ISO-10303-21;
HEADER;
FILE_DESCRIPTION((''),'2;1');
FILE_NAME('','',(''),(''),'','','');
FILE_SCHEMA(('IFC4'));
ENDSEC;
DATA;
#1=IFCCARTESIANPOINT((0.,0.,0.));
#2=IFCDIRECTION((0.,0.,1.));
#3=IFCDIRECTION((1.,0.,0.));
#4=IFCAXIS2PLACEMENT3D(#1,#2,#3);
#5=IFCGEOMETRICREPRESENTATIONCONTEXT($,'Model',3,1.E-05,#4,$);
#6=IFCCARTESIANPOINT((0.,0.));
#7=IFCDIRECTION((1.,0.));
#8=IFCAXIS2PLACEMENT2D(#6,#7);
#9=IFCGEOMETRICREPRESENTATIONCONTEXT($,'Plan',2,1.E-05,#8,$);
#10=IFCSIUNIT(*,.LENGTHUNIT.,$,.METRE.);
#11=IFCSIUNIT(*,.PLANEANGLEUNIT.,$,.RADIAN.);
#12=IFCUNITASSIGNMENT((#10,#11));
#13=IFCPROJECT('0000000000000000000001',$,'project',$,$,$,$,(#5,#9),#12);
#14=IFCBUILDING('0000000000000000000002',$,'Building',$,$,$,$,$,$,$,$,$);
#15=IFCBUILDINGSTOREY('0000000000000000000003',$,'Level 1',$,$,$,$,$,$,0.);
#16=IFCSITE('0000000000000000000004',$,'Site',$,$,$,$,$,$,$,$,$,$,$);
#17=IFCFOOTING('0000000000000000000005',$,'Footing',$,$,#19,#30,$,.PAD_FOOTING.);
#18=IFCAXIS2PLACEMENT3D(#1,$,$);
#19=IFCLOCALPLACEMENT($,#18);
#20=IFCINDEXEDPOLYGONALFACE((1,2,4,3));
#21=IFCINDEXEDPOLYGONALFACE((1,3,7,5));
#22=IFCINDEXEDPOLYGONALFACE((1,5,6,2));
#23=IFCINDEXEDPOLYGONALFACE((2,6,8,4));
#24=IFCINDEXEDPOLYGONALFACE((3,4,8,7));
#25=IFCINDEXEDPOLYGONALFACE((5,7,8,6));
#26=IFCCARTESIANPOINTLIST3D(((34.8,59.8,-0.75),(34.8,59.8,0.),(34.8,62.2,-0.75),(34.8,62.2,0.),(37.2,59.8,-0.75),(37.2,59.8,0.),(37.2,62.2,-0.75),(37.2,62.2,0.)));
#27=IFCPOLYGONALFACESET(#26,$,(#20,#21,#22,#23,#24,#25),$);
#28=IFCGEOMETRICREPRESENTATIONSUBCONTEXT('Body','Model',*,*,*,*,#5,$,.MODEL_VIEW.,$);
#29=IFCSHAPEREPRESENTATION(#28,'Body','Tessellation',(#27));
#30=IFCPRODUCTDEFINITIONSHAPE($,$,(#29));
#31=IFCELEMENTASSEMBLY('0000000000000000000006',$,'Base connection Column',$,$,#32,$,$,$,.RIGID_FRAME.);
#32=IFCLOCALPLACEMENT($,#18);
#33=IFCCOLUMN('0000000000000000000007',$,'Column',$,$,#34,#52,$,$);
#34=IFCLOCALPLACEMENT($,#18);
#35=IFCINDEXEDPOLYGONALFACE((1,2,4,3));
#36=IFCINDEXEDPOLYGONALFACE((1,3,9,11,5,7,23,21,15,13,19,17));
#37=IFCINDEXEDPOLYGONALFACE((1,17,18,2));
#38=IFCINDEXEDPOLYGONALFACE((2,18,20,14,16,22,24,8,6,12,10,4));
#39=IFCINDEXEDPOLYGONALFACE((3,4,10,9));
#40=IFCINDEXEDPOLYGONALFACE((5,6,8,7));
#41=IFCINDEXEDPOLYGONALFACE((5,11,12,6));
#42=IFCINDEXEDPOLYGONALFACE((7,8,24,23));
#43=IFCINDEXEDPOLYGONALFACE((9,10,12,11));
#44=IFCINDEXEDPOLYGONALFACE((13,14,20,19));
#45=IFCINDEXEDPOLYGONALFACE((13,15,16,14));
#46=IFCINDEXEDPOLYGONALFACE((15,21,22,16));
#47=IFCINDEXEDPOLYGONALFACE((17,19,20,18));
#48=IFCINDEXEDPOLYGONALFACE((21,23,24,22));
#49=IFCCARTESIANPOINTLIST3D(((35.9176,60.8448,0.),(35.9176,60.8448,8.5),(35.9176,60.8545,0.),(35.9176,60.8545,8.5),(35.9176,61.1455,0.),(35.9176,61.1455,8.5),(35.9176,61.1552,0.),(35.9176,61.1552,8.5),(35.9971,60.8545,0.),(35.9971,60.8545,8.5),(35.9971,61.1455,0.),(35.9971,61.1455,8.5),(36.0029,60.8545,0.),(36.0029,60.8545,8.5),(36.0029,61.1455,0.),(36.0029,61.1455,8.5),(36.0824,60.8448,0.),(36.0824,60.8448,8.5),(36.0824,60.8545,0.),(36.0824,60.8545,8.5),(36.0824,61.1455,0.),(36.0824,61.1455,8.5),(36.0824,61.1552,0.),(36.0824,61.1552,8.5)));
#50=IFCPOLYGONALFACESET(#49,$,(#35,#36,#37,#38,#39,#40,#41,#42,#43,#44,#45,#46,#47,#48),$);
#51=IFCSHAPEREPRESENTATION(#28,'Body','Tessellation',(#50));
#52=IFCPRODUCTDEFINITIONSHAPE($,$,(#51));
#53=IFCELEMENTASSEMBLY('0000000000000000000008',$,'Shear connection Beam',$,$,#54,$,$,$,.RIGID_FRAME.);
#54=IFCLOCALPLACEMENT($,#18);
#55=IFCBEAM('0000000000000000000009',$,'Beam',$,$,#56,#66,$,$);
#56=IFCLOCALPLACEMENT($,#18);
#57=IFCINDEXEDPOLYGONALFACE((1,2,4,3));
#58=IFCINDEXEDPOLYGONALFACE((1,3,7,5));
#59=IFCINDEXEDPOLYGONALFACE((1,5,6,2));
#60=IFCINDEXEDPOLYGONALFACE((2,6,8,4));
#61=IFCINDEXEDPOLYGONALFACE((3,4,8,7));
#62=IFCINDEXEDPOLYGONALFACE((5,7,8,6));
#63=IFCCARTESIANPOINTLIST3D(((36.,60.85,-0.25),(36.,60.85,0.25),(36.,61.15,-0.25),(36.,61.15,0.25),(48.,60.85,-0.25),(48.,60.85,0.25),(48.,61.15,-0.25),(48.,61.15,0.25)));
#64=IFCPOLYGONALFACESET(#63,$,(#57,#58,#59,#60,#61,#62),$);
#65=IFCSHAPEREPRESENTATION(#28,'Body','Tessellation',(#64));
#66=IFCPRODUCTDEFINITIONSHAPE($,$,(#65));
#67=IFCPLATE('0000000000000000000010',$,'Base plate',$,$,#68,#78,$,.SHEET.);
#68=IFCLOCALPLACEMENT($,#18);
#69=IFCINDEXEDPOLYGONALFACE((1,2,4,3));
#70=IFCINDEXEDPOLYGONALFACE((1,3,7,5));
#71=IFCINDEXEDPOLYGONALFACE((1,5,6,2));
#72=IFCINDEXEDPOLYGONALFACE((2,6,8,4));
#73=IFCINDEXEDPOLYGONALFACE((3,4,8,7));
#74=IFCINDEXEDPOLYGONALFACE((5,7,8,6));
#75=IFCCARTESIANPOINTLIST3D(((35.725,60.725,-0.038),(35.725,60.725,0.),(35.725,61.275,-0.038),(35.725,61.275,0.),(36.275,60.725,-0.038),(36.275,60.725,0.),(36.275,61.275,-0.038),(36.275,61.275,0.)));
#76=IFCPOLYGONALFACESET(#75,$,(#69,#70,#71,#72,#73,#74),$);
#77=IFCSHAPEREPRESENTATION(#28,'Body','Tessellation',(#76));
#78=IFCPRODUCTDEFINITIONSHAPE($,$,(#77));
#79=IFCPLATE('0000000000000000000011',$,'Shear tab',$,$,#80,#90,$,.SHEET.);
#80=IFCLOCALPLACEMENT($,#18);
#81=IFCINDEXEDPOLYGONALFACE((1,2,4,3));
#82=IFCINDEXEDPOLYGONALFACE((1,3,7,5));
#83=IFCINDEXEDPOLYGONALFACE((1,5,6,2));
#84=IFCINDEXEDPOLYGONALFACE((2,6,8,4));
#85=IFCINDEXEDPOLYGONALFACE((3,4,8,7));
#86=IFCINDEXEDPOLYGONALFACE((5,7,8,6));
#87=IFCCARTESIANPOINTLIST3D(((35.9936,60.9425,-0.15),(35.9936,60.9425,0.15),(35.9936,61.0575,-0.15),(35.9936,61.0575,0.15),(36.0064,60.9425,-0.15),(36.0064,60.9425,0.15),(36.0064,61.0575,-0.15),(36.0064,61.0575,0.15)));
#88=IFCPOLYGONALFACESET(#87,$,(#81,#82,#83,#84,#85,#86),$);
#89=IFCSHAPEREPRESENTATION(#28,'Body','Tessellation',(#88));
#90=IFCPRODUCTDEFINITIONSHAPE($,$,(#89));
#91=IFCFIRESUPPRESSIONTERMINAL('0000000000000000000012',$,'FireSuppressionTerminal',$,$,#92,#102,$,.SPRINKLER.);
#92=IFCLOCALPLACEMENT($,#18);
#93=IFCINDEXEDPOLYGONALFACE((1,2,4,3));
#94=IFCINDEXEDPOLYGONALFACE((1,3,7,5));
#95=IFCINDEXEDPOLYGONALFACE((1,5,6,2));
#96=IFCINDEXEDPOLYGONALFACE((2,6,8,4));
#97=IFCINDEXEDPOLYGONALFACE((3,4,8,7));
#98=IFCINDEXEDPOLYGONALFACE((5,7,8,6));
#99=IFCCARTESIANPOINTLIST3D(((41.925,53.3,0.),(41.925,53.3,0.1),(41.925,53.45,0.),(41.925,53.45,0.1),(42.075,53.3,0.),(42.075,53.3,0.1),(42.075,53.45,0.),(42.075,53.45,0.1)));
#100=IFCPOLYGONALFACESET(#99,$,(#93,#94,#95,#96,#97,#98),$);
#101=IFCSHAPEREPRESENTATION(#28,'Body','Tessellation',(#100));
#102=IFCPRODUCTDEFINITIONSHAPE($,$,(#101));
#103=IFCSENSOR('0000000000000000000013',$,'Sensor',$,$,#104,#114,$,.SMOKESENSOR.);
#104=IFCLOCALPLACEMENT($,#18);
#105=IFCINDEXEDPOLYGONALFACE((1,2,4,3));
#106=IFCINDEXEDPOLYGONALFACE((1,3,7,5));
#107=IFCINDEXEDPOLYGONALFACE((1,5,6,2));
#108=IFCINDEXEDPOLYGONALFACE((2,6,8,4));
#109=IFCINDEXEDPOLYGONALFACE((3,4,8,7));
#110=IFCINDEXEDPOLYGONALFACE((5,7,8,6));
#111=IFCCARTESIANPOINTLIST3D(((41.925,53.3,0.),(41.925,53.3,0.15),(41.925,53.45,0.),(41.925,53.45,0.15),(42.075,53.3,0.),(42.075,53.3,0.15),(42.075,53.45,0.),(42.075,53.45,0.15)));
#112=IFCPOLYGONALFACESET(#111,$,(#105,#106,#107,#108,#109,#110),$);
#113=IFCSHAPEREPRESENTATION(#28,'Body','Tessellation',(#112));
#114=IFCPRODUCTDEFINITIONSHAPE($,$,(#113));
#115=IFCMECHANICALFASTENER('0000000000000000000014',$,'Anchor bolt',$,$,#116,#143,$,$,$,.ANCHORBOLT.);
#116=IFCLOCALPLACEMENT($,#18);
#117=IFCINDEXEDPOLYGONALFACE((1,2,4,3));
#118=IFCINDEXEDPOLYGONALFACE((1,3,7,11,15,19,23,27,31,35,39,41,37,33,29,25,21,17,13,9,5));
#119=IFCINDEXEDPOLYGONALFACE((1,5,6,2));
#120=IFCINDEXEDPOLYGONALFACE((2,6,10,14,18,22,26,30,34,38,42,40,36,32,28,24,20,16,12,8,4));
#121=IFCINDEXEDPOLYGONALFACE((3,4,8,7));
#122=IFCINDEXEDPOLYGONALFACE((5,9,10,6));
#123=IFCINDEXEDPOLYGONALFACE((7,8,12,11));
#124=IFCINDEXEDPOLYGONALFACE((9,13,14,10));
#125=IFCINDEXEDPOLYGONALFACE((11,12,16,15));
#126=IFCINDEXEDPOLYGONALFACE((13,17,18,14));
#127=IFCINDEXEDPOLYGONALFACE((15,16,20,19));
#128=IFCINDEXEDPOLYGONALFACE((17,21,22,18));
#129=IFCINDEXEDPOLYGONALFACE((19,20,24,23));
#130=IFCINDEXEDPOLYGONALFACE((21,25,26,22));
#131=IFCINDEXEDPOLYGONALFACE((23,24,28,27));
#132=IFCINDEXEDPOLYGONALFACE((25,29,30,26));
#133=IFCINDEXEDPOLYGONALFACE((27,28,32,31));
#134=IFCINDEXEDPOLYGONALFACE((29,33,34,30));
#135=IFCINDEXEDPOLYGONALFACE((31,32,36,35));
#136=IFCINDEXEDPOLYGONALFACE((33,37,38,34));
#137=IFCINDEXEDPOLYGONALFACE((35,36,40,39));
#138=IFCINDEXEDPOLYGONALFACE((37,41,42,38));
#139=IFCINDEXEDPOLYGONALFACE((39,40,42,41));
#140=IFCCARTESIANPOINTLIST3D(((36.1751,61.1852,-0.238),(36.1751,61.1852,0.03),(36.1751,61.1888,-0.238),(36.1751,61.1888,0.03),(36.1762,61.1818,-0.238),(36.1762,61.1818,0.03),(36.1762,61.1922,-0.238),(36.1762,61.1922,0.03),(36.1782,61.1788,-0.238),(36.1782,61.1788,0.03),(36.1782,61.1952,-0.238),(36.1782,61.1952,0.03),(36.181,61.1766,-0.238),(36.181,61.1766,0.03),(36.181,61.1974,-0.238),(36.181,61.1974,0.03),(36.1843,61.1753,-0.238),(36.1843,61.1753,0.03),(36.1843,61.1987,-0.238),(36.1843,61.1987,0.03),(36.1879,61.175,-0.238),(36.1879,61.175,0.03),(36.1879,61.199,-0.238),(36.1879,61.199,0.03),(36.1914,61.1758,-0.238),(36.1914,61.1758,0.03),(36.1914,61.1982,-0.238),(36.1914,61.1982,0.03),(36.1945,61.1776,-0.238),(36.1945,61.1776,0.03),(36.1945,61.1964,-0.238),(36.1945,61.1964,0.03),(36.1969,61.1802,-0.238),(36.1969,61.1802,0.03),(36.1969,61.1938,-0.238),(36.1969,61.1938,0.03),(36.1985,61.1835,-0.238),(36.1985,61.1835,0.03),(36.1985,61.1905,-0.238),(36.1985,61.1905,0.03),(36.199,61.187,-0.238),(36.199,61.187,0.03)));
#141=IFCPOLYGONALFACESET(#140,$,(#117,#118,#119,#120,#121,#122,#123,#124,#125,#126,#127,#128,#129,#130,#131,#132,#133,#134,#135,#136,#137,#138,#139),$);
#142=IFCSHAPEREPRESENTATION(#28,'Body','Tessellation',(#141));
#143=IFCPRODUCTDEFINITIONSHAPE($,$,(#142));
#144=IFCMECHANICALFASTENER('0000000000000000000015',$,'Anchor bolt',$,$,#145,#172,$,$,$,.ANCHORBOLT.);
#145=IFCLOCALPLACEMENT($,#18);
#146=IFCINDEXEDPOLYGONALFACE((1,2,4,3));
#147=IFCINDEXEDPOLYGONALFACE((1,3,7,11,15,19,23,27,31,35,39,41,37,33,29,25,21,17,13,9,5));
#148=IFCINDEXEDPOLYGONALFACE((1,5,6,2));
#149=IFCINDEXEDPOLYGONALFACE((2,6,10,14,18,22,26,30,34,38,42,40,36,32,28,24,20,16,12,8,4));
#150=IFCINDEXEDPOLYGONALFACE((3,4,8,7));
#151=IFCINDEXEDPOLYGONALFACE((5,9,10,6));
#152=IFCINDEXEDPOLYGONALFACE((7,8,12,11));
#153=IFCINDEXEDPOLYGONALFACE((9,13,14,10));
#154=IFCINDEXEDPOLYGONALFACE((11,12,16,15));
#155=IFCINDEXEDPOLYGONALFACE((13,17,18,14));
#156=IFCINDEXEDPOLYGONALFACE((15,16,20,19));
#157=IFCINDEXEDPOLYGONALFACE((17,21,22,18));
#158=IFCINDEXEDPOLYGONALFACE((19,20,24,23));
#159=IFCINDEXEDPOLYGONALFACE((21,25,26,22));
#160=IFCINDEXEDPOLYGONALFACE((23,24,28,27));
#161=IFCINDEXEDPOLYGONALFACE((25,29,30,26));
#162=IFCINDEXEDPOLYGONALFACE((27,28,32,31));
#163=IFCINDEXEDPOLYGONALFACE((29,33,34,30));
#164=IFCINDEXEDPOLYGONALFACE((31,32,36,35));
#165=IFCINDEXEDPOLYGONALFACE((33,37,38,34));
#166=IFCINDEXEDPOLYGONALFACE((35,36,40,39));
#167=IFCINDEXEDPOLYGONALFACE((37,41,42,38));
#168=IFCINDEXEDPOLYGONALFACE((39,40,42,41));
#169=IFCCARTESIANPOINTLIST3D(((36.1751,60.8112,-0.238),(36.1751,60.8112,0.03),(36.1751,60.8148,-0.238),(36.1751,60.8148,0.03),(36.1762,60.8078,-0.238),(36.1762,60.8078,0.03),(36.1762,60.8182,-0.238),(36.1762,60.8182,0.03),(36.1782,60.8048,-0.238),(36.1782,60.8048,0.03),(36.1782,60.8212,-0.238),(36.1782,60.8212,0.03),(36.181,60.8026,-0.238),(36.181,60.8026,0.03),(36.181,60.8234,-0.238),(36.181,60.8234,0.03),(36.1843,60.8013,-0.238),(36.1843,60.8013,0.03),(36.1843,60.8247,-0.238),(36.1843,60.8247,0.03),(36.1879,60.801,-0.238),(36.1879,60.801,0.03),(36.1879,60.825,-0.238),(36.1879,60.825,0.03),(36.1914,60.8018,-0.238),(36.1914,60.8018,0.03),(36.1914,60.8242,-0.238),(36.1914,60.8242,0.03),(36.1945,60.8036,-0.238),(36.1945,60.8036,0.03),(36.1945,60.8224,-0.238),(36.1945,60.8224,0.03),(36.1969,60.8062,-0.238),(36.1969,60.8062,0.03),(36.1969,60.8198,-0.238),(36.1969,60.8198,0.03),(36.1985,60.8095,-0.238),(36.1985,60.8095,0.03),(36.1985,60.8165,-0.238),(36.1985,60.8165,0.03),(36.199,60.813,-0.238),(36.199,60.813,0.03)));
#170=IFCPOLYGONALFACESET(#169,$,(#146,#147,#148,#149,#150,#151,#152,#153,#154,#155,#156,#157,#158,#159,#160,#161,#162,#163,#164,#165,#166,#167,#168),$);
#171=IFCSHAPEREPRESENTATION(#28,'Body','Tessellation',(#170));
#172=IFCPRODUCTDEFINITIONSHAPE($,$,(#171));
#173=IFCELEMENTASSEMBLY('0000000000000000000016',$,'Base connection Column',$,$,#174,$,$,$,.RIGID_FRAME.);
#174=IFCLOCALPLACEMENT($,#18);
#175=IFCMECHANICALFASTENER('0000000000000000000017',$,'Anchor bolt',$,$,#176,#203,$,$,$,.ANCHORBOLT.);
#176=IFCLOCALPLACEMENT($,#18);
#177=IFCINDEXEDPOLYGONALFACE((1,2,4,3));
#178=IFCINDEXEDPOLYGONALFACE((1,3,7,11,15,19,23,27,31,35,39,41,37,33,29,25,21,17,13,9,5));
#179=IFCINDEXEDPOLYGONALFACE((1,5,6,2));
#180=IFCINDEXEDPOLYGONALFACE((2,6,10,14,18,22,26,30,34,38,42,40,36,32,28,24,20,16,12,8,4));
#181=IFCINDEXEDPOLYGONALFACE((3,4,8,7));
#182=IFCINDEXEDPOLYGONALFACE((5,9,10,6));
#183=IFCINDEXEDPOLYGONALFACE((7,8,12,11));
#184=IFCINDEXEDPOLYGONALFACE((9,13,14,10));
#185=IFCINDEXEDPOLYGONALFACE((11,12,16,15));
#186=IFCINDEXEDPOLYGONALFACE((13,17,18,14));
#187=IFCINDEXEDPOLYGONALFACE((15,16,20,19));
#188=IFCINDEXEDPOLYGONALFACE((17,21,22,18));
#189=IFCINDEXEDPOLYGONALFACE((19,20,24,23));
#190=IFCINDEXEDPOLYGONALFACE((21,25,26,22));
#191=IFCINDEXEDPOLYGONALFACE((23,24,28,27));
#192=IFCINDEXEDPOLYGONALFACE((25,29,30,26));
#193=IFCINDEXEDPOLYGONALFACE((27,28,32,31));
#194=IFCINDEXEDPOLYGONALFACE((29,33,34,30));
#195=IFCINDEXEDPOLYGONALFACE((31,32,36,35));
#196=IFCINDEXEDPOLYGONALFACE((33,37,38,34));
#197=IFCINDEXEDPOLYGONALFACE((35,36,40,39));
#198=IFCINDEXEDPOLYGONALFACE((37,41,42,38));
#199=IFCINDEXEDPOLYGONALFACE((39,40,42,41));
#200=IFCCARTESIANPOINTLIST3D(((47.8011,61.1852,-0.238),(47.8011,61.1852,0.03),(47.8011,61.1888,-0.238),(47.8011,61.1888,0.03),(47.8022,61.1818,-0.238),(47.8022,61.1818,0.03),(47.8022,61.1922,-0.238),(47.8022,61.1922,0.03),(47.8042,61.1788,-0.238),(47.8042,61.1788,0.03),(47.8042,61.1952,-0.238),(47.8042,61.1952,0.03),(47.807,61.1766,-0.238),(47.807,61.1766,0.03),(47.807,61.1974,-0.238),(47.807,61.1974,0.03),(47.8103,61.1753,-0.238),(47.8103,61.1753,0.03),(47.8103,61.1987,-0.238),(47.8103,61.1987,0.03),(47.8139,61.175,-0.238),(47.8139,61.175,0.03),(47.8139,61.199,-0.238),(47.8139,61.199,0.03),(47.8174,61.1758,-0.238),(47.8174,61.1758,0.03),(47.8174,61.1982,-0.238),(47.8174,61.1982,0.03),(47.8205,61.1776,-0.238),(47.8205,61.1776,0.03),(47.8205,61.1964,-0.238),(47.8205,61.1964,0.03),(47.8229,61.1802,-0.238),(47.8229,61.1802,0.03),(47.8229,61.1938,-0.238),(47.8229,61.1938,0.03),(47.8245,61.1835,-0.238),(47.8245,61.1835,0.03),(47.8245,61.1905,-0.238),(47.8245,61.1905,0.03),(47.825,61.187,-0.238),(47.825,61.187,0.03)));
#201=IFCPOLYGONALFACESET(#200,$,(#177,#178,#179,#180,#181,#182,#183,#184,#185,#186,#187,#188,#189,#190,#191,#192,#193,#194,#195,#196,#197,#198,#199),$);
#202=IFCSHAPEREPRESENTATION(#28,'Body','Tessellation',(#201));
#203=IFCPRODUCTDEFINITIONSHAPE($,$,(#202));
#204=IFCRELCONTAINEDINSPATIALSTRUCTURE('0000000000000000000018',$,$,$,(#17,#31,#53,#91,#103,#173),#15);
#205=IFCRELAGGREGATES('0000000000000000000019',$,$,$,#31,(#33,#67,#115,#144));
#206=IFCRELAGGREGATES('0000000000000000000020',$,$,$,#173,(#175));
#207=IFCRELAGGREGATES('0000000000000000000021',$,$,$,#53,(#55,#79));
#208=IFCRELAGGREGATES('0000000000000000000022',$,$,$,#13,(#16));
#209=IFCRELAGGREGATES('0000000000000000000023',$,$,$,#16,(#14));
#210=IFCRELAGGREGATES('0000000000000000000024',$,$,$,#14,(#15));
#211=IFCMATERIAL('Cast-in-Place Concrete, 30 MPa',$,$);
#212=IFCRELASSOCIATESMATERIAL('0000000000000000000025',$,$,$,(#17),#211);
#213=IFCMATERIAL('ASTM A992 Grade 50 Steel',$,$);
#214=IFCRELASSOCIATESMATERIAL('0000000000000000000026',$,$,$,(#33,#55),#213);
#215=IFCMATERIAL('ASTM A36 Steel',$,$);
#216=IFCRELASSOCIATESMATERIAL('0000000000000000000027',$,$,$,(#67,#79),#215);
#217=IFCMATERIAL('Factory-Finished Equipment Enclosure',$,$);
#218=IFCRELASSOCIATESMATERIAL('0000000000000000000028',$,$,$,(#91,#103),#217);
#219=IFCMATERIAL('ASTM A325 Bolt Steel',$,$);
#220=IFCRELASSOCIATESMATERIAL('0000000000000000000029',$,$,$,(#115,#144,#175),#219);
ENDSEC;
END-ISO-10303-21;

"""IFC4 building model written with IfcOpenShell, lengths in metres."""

from ifc_helpers import new_model, si_unit, frame, origin_with_axes, origin_2d, origin_2d_with_axis, place, context, subcontext, project, spatial, rectangle, circle, i_section, extrude, material, element, aggregate, save


model = new_model("IFC4")

# Units and contexts
model_context = context("Model", 3, precision=1e-05, world=origin_with_axes())
plan_context = context("Plan", 2, precision=1e-05, world=origin_2d_with_axis())
body_context = subcontext(model_context, "Body", "Model", "MODEL_VIEW")
ifc_project = project(units=[si_unit("LENGTHUNIT", "METRE"), si_unit("PLANEANGLEUNIT", "RADIAN")], contexts=[model_context, plan_context])

# Site, building, storey
site = spatial("IfcSite", under=ifc_project, Name="Site")
building = spatial("IfcBuilding", under=site, Name="Building")
storey = spatial("IfcBuildingStorey", under=building, Name="Level 1", Elevation=0.0)

# Footing
ifc_material_1 = material(Name="Cast-in-Place Concrete, 30 MPa")
footing_placement = place(None, frame((36.0, 61.0, -0.75), z_axis=(0.0, 0.0, 1.0), x_axis=(1.0, 0.0, 0.0)))
element("IfcFooting", 1, at=footing_placement, inside=storey, material=ifc_material_1, Name="Footing", PredefinedType="PAD_FOOTING", context=body_context, shape_type="SweptSolid", body=[
    extrude(rectangle(XDim=2.4, YDim=2.4, at=origin_2d_with_axis()), origin_with_axes(), (0.0, 0.0, 1.0), 0.75),
])

# Element assembly, column
assembly_1 = element("IfcElementAssembly", 2, inside=storey, Name="Base connection Column", PredefinedType="RIGID_FRAME")
ifc_material_2 = material(Name="ASTM A992 Grade 50 Steel")
column_placement = place(None, frame((36.0, 61.0, 0.0), z_axis=(0.0, 0.0, 1.0), x_axis=(1.0, 0.0, 0.0)))
column = element("IfcColumn", 3, at=column_placement, material=ifc_material_2, Name="Column", context=body_context, shape_type="SweptSolid", body=[
    extrude(i_section(OverallWidth=0.1648, OverallDepth=0.3104, WebThickness=0.0058, FlangeThickness=0.0097, at=origin_2d_with_axis()), origin_with_axes(), (0.0, 0.0, 1.0), 8.5),
])

# Element assembly, beam
assembly_2 = element("IfcElementAssembly", 4, inside=storey, Name="Shear connection Beam", PredefinedType="RIGID_FRAME")
beam_placement = place(None, frame((36.0, 61.0, 0.0), z_axis=(1.0, 0.0, 0.0), x_axis=(0.0, 1.0, 0.0)))
beam = element("IfcBeam", 5, at=beam_placement, material=ifc_material_2, Name="Beam", context=body_context, shape_type="SweptSolid", body=[
    extrude(rectangle(XDim=0.3, YDim=0.5, at=origin_2d_with_axis()), origin_with_axes(), (0.0, 0.0, 1.0), 12.0),
])

# Plates
ifc_material_3 = material(Name="ASTM A36 Steel")
plate_1_placement = place(None, frame((36.0, 61.0, -0.038), z_axis=(0.0, 0.0, 1.0), x_axis=(1.0, 0.0, 0.0)))
plate_1 = element("IfcPlate", 6, at=plate_1_placement, material=ifc_material_3, Name="Base plate", PredefinedType="SHEET", context=body_context, shape_type="SweptSolid", body=[
    extrude(rectangle(XDim=0.55, YDim=0.55, at=origin_2d_with_axis()), origin_with_axes(), (0.0, 0.0, 1.0), 0.038),
])
plate_2_placement = place(None, frame((36.0, 61.0, -0.15), z_axis=(0.0, 0.0, 1.0), x_axis=(1.0, 0.0, 0.0)))
plate_2 = element("IfcPlate", 7, at=plate_2_placement, material=ifc_material_3, Name="Shear tab", PredefinedType="SHEET", context=body_context, shape_type="SweptSolid", body=[
    extrude(rectangle(XDim=0.0127, YDim=0.115, at=origin_2d_with_axis()), origin_with_axes(), (0.0, 0.0, 1.0), 0.3),
])

# Fire suppression terminal
ifc_material_4 = material(Name="Factory-Finished Equipment Enclosure")
fire_suppression_terminal_placement = place(None, frame((42.0, 53.375, 0.0), z_axis=(0.0, 0.0, 1.0), x_axis=(1.0, 0.0, 0.0)))
element("IfcFireSuppressionTerminal", 8, at=fire_suppression_terminal_placement, inside=storey, material=ifc_material_4, Name="FireSuppressionTerminal", PredefinedType="SPRINKLER", context=body_context, shape_type="SweptSolid", body=[
    extrude(rectangle(XDim=0.15, YDim=0.15, at=origin_2d_with_axis()), origin_with_axes(), (0.0, 0.0, 1.0), 0.1),
])

# Sensor
sensor_placement = place(None, frame((42.0, 53.375, 0.0), z_axis=(0.0, 0.0, 1.0), x_axis=(1.0, 0.0, 0.0)))
element("IfcSensor", 9, at=sensor_placement, inside=storey, material=ifc_material_4, Name="Sensor", PredefinedType="SMOKESENSOR", context=body_context, shape_type="SweptSolid", body=[
    extrude(rectangle(XDim=0.15, YDim=0.15, at=origin_2d_with_axis()), origin_with_axes(), (0.0, 0.0, 1.0), 0.15),
])

# Mechanical fasteners
ifc_material_5 = material(Name="ASTM A325 Bolt Steel")
mechanical_fastener_1_placement = place(None, frame((36.187, 61.187, -0.238), z_axis=(0.0, 0.0, 1.0), x_axis=(1.0, 0.0, 0.0)))
mechanical_fastener_1 = element("IfcMechanicalFastener", 10, at=mechanical_fastener_1_placement, material=ifc_material_5, Name="Anchor bolt", PredefinedType="ANCHORBOLT", context=body_context, shape_type="SweptSolid", body=[
    extrude(circle(Radius=0.012, at=origin_2d()), origin_with_axes(), (0.0, 0.0, 1.0), 0.268),
])
mechanical_fastener_2_placement = place(None, frame((36.187, 60.813, -0.238), z_axis=(0.0, 0.0, 1.0), x_axis=(1.0, 0.0, 0.0)))
mechanical_fastener_2 = element("IfcMechanicalFastener", 11, at=mechanical_fastener_2_placement, material=ifc_material_5, Name="Anchor bolt", PredefinedType="ANCHORBOLT", context=body_context, shape_type="SweptSolid", body=[
    extrude(circle(Radius=0.012, at=origin_2d()), origin_with_axes(), (0.0, 0.0, 1.0), 0.268),
])
aggregate(assembly_1, [column, plate_1, mechanical_fastener_1, mechanical_fastener_2])

# Element assembly, mechanical fastener
assembly_3 = element("IfcElementAssembly", 12, inside=storey, Name="Base connection Column", PredefinedType="RIGID_FRAME")
mechanical_fastener_3_placement = place(None, frame((47.813, 61.187, -0.238), z_axis=(0.0, 0.0, 1.0), x_axis=(1.0, 0.0, 0.0)))
mechanical_fastener_3 = element("IfcMechanicalFastener", 13, at=mechanical_fastener_3_placement, material=ifc_material_5, Name="Anchor bolt", PredefinedType="ANCHORBOLT", context=body_context, shape_type="SweptSolid", body=[
    extrude(circle(Radius=0.012, at=origin_2d()), origin_with_axes(), (0.0, 0.0, 1.0), 0.268),
])
aggregate(assembly_3, [mechanical_fastener_3])

aggregate(assembly_2, [beam, plate_2])

save(model, "model.ifc")
